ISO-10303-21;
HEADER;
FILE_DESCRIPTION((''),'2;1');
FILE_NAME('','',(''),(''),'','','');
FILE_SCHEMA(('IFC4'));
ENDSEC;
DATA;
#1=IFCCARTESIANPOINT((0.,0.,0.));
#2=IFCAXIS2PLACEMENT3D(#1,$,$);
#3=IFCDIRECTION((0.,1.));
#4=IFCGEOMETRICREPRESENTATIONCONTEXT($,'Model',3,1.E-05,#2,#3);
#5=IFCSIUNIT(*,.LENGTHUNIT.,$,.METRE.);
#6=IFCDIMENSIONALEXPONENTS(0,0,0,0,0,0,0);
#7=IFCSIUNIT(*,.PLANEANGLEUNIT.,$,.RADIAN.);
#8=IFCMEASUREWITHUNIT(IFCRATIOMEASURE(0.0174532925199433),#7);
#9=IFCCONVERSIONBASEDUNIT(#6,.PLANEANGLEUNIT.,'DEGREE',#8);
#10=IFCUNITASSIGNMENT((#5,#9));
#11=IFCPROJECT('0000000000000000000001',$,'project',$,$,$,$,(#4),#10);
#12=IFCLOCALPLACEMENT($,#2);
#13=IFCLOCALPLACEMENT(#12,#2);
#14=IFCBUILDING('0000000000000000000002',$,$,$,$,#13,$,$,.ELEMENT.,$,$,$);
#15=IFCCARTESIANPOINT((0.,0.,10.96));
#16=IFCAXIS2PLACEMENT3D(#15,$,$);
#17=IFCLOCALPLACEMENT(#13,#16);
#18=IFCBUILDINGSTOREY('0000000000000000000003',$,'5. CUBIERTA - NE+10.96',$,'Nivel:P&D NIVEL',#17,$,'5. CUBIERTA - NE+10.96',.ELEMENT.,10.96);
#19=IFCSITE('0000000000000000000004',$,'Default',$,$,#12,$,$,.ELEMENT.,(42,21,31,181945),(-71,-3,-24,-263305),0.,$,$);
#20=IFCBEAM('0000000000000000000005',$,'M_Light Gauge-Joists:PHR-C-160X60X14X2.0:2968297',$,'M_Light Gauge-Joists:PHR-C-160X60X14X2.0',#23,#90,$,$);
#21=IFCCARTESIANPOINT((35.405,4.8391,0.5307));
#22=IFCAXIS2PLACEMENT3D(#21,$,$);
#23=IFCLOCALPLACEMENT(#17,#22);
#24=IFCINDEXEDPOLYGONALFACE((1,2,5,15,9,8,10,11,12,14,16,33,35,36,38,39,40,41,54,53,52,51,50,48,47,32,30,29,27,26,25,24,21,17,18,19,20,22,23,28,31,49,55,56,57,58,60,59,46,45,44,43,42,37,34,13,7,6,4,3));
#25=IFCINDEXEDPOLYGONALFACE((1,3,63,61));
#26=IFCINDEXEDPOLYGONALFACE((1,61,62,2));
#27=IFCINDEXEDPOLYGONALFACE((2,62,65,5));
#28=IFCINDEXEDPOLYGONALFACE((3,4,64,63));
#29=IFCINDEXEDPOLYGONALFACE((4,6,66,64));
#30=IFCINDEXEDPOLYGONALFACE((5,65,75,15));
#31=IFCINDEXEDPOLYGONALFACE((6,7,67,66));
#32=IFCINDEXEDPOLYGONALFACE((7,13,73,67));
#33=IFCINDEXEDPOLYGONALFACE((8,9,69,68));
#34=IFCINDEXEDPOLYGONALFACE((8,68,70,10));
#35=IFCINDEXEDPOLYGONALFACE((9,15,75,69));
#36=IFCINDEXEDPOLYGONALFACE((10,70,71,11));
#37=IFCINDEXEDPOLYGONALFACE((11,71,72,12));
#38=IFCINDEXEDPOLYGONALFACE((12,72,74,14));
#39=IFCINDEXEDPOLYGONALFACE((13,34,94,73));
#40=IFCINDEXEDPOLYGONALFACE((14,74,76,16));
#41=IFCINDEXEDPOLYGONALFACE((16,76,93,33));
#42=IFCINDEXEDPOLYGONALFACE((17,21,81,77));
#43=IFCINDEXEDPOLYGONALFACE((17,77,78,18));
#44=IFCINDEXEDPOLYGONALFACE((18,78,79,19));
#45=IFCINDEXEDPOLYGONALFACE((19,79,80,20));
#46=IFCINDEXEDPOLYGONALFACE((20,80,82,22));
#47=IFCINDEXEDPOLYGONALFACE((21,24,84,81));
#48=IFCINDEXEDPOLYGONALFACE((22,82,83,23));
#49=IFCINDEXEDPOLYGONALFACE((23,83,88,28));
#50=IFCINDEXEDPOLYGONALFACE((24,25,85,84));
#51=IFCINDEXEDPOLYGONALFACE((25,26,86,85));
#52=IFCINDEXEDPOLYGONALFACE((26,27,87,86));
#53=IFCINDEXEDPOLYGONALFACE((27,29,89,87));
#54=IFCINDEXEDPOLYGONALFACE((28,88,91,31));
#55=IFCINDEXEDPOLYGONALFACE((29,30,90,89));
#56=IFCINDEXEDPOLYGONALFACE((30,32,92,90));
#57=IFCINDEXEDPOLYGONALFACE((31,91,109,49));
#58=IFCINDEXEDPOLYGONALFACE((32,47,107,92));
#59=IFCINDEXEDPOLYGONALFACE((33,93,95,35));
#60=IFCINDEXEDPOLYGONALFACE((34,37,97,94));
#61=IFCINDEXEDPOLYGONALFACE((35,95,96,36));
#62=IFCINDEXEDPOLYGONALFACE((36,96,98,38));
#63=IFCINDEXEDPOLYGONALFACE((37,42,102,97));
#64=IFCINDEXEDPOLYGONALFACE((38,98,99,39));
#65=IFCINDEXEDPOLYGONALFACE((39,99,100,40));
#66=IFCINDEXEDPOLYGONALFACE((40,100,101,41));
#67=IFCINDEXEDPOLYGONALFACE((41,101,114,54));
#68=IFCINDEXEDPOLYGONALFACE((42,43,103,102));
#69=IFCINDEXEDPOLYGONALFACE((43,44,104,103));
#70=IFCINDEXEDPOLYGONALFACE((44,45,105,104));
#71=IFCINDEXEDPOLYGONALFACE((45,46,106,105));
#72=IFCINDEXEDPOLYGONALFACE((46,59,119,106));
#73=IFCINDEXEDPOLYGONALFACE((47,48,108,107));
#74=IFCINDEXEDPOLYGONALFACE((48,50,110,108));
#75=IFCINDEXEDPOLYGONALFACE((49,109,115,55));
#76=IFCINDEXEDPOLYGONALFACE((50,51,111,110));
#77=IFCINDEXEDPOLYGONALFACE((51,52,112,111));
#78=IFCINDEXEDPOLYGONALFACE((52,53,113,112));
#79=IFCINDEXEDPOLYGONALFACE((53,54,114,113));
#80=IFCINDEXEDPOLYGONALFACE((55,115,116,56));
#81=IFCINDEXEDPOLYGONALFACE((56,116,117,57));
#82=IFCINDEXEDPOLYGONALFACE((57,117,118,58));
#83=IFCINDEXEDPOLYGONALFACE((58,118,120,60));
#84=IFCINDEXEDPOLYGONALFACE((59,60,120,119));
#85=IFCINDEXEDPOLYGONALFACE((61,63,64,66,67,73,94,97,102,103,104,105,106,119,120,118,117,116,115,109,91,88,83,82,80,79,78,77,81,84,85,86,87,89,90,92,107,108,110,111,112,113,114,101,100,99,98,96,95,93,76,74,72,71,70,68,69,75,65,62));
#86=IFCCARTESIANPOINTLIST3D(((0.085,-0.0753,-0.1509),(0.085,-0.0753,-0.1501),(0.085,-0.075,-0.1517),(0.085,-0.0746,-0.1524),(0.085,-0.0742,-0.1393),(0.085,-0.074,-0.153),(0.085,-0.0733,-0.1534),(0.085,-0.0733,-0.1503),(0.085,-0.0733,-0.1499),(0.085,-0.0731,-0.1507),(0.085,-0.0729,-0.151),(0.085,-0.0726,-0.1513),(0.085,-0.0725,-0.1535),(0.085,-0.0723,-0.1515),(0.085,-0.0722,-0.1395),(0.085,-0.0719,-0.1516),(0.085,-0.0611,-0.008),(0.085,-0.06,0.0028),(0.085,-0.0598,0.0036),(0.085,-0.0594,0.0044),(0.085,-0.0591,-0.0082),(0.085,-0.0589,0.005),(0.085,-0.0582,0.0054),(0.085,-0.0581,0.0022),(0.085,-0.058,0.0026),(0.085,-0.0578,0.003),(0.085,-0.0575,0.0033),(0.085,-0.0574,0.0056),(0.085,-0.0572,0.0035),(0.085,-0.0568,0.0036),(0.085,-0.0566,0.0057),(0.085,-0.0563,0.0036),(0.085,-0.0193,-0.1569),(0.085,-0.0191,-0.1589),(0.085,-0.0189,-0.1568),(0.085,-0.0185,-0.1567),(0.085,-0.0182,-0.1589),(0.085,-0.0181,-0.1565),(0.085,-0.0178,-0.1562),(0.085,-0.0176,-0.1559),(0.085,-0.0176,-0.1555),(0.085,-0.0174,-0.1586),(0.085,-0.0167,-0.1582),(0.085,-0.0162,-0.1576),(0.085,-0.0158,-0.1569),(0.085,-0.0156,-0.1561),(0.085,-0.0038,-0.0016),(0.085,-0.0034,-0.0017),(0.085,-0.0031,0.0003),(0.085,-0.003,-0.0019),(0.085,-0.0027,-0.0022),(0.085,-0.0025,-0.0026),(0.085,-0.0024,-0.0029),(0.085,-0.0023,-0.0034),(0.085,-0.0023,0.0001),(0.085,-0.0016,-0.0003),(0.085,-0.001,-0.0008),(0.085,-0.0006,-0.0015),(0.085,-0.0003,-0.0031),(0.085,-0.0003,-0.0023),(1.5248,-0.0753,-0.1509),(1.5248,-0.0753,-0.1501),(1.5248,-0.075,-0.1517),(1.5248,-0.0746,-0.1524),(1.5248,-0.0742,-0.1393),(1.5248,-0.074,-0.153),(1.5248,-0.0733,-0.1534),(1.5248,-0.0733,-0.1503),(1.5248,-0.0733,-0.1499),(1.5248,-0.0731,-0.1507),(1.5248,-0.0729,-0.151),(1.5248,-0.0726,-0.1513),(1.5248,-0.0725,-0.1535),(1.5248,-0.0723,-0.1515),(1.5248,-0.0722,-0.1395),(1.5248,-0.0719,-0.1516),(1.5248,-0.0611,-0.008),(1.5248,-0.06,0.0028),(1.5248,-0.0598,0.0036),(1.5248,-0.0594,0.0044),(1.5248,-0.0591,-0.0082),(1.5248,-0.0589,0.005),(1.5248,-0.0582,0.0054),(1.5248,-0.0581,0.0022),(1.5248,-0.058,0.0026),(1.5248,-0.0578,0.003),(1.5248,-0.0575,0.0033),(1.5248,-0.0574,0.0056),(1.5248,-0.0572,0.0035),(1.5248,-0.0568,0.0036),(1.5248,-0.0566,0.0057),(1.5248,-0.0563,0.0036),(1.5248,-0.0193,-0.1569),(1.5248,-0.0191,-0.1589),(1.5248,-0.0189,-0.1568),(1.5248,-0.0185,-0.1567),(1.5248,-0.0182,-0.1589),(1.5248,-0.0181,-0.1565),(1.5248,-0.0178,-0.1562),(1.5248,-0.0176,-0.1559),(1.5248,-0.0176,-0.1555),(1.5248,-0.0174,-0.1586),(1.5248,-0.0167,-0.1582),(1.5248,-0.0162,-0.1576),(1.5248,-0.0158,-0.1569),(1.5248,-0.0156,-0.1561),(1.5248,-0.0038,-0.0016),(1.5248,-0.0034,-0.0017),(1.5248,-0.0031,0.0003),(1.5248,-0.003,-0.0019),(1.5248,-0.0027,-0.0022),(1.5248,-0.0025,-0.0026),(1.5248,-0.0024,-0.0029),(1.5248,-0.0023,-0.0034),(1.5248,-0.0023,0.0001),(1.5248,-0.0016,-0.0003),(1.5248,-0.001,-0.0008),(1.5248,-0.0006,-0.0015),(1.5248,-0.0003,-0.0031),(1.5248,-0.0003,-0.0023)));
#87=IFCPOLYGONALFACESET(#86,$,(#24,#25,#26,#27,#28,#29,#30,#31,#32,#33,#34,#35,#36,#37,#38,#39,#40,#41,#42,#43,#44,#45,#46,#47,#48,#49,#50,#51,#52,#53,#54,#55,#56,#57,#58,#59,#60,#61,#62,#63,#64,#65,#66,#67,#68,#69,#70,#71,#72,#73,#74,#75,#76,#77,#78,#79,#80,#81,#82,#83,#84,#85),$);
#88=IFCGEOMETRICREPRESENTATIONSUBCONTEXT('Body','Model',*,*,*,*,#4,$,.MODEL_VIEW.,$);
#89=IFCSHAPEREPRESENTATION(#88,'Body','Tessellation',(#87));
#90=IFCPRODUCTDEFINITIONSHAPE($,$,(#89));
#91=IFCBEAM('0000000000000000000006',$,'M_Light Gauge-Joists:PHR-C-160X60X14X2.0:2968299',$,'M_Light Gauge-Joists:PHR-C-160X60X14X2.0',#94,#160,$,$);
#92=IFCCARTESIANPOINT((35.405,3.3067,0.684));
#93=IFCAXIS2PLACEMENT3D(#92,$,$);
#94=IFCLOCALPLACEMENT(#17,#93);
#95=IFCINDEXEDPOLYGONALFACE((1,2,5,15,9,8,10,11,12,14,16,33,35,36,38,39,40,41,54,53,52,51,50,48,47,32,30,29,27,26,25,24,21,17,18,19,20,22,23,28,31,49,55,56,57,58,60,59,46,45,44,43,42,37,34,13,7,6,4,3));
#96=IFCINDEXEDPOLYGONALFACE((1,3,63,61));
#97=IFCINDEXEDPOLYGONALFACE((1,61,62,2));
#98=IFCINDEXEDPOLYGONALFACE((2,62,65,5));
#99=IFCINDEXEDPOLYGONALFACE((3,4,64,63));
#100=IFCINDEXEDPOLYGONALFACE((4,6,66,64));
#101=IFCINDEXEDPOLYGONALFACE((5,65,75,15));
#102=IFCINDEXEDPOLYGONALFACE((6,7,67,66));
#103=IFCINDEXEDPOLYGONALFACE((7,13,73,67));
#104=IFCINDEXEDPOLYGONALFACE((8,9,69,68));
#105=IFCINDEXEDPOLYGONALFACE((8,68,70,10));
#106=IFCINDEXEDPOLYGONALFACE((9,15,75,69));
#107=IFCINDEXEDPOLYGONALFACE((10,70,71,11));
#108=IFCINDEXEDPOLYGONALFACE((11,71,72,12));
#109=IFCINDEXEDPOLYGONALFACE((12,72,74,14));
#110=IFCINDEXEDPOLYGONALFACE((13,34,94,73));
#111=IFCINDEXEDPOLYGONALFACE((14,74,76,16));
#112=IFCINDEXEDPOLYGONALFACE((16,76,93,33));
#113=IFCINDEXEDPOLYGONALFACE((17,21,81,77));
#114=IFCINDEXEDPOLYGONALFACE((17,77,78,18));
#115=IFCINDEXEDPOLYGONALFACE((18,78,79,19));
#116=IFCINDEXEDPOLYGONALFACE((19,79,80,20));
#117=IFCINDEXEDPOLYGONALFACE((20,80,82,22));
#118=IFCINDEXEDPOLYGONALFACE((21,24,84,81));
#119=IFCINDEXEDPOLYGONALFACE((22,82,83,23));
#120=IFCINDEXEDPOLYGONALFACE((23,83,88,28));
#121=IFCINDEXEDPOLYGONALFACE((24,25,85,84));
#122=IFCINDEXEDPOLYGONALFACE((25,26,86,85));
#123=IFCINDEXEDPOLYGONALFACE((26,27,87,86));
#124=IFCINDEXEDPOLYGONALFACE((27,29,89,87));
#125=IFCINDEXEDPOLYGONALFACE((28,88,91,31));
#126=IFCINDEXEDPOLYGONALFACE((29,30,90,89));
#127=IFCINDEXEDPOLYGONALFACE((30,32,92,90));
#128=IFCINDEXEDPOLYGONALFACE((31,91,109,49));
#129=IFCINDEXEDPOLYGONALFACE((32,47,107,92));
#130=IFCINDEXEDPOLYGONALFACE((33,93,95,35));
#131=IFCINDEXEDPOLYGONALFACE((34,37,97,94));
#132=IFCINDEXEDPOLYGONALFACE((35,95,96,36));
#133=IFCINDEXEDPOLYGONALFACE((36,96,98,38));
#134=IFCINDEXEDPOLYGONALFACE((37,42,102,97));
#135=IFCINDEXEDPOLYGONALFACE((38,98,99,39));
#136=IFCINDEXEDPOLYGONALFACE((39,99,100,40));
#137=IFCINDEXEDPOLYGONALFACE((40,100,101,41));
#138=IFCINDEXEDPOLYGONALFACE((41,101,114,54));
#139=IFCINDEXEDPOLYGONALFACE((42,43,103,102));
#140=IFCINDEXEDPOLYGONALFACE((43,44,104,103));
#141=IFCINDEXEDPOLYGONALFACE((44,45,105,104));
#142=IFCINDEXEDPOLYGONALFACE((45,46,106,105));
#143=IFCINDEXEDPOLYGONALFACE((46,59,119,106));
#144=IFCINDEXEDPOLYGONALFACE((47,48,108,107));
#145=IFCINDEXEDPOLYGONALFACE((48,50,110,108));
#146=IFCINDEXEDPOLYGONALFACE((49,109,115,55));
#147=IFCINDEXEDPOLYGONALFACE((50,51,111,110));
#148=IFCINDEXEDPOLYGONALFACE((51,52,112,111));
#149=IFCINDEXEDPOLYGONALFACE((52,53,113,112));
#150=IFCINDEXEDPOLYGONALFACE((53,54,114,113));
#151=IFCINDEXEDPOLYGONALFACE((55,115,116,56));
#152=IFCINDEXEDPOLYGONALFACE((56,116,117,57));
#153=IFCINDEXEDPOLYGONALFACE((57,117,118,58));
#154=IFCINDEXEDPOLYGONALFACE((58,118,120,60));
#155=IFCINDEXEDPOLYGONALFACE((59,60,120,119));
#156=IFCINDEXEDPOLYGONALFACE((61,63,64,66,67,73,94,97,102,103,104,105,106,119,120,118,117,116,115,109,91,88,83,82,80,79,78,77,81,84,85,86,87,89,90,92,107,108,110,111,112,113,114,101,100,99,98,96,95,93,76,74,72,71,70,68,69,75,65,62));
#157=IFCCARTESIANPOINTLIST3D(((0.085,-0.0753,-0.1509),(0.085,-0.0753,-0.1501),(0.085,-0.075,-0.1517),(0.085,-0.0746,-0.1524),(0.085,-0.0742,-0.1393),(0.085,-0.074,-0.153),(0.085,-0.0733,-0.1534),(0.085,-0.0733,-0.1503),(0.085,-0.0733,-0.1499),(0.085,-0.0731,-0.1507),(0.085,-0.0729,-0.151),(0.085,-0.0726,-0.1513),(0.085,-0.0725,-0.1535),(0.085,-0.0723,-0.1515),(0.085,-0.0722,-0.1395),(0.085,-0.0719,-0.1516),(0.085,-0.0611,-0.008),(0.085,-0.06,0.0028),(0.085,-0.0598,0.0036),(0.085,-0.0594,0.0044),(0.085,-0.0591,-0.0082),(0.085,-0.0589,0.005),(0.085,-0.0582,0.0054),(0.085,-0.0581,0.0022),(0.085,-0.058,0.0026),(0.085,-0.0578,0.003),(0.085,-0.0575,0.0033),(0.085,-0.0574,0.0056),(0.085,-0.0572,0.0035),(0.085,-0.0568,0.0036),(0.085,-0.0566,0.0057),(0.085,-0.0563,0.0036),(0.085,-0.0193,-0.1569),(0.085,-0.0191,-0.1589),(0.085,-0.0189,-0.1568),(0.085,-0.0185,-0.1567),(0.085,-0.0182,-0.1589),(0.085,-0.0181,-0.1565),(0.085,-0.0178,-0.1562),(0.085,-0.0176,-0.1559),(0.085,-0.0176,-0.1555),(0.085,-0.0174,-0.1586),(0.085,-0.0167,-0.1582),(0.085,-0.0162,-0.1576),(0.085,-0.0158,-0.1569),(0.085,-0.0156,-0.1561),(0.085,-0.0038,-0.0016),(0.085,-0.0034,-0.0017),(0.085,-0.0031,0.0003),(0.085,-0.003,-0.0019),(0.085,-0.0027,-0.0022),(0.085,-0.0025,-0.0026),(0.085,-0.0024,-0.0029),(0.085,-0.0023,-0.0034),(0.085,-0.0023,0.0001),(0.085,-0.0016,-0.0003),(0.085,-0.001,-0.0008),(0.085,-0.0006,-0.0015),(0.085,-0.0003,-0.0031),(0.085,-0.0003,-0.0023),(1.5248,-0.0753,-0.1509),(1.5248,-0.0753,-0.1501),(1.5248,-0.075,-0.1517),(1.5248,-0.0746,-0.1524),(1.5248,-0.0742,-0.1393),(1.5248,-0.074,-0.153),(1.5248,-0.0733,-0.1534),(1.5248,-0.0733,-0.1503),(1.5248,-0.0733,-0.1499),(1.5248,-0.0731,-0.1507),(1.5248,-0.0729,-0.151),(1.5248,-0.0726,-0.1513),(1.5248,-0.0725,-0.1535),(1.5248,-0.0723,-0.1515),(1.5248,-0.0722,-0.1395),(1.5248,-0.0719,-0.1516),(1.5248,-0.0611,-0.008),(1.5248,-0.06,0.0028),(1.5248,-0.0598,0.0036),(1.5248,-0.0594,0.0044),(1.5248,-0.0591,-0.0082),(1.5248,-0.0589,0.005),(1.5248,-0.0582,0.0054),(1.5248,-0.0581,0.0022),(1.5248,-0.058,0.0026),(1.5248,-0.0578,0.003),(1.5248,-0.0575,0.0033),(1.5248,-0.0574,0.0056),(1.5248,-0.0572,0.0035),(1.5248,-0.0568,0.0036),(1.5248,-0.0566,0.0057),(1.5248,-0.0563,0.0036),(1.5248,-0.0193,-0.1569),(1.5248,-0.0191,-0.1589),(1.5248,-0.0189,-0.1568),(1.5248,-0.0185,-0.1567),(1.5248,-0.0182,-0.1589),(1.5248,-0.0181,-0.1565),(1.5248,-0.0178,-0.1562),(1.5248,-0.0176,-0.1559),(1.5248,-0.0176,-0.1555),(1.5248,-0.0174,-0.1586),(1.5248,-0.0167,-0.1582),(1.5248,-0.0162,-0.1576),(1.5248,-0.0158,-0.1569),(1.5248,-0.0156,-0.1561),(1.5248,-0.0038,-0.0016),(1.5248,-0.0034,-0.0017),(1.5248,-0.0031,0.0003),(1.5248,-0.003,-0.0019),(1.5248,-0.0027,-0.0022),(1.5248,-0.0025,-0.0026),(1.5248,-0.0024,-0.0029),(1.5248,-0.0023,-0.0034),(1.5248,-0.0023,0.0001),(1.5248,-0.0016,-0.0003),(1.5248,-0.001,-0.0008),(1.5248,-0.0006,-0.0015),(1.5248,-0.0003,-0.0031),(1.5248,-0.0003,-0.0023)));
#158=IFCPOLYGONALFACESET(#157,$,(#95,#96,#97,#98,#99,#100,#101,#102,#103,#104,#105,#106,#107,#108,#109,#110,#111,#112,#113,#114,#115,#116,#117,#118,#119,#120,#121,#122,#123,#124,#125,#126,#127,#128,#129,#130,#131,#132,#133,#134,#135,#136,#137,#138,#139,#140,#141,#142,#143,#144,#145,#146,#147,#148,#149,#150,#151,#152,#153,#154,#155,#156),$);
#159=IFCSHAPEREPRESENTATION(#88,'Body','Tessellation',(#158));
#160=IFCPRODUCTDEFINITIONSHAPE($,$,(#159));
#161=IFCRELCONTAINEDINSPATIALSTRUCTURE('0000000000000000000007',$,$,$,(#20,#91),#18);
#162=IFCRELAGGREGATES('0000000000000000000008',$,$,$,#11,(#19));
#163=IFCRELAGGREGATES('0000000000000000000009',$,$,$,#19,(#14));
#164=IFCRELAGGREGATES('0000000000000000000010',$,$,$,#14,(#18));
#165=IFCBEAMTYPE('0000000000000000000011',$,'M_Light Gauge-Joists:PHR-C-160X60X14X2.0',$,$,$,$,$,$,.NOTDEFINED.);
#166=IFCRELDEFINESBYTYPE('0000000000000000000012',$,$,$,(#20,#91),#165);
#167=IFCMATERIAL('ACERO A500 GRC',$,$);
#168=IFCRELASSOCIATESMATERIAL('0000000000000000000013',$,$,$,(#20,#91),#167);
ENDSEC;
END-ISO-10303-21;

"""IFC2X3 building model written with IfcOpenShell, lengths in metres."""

from ifc_helpers import new_model, entity, si_unit, converted_unit, direction, frame, frame_2d, origin, place, context, subcontext, project, spatial, polyline, circle_curve, parameter, trimmed, segment, composite_curve, outline, extrude, material, type_object, element, save


model = new_model("IFC2X3")

# Units and contexts
model_context = context("Model", 3, precision=1e-05, world=origin(), true_north=direction((0.0, 1.0)))
body_context = subcontext(model_context, "Body", "Model", "MODEL_VIEW")
ifc_project = project(units=[si_unit("LENGTHUNIT", "METRE"), converted_unit("PLANEANGLEUNIT", "DEGREE", entity("IfcRatioMeasure", 0.0174532925199433), si_unit("PLANEANGLEUNIT", "RADIAN"), dimensions=[0, 0, 0, 0, 0, 0, 0])], contexts=[model_context])

# Site, building, storey
site_placement = place(None, origin())
site = spatial("IfcSite", under=ifc_project, at=site_placement, Name="Default", CompositionType="ELEMENT", RefLatitude=(42, 21, 31, 181945), RefLongitude=(-71, -3, -24, -263305), RefElevation=0.0)
building_placement = place(site_placement, origin())
building = spatial("IfcBuilding", under=site, at=building_placement, CompositionType="ELEMENT")
storey_placement = place(building_placement, frame((0.0, 0.0, 10.96)))
storey = spatial("IfcBuildingStorey", under=building, at=storey_placement, Name="5. CUBIERTA - NE+10.96", ObjectType="Nivel:P&D NIVEL", LongName="5. CUBIERTA - NE+10.96", CompositionType="ELEMENT", Elevation=10.96)

# Beams
ifc_material_1 = material(Name="ACERO A500 GRC")
beam_type_1 = type_object("IfcBeamType", Name="M_Light Gauge-Joists:PHR-C-160X60X14X2.0", PredefinedType="NOTDEFINED")
beam_1_placement = place(storey_placement, frame((35.405, 4.8391, 0.5307)))
element("IfcBeam", 1, at=beam_1_placement, inside=storey, type_object=beam_type_1, material=ifc_material_1, Name="M_Light Gauge-Joists:PHR-C-160X60X14X2.0:2968297", ObjectType="M_Light Gauge-Joists:PHR-C-160X60X14X2.0", context=body_context, shape_type="SweptSolid", body=[
    extrude(outline(composite_curve([segment(polyline([(-0.0768, -0.0358), (0.0768, -0.0358)]), True, "CONTINUOUS"), segment(trimmed(circle_curve(frame_2d((0.0768, -0.0326), x_axis=(0.0, -1.0)), 0.0032), [parameter(0.0)], [parameter(90.0)], True, "PARAMETER"), True, "CONTINUOUS"), segment(polyline([(0.08, -0.0326), (0.08, 0.021)]), True, "CONTINUOUS"), segment(trimmed(circle_curve(frame_2d((0.0768, 0.021), x_axis=(1.0, 0.0)), 0.0032), [parameter(0.0)], [parameter(90.0)], True, "PARAMETER"), True, "CONTINUOUS"), segment(polyline([(0.0768, 0.0242), (0.066, 0.0242)]), True, "CONTINUOUS"), segment(polyline([(0.066, 0.0242), (0.066, 0.0222)]), True, "CONTINUOUS"), segment(polyline([(0.066, 0.0222), (0.0764, 0.0222)]), True, "CONTINUOUS"), segment(trimmed(circle_curve(frame_2d((0.0764, 0.0206), x_axis=(0.0, 1.0)), 0.0016), [parameter(270.0)], [parameter(0.0)], True, "PARAMETER"), False, "CONTINUOUS"), segment(polyline([(0.078, 0.0206), (0.078, -0.0322)]), True, "CONTINUOUS"), segment(trimmed(circle_curve(frame_2d((0.0764, -0.0322), x_axis=(1.0, 0.0)), 0.0016), [parameter(270.0)], [parameter(0.0)], True, "PARAMETER"), False, "CONTINUOUS"), segment(polyline([(0.0764, -0.0338), (-0.0764, -0.0338)]), True, "CONTINUOUS"), segment(trimmed(circle_curve(frame_2d((-0.0764, -0.0322), x_axis=(0.0, -1.0)), 0.0016), [parameter(270.0)], [parameter(0.0)], True, "PARAMETER"), False, "CONTINUOUS"), segment(polyline([(-0.078, -0.0322), (-0.078, 0.0206)]), True, "CONTINUOUS"), segment(trimmed(circle_curve(frame_2d((-0.0764, 0.0206), x_axis=(-1.0, 0.0)), 0.0016), [parameter(270.0)], [parameter(0.0)], True, "PARAMETER"), False, "CONTINUOUS"), segment(polyline([(-0.0764, 0.0222), (-0.066, 0.0222)]), True, "CONTINUOUS"), segment(polyline([(-0.066, 0.0222), (-0.066, 0.0242)]), True, "CONTINUOUS"), segment(polyline([(-0.066, 0.0242), (-0.0768, 0.0242)]), True, "CONTINUOUS"), segment(trimmed(circle_curve(frame_2d((-0.0768, 0.021), x_axis=(0.0, 1.0)), 0.0032), [parameter(0.0)], [parameter(90.0)], True, "PARAMETER"), True, "CONTINUOUS"), segment(polyline([(-0.08, 0.021), (-0.08, -0.0326)]), True, "CONTINUOUS"), segment(trimmed(circle_curve(frame_2d((-0.0768, -0.0326), x_axis=(-1.0, 0.0)), 0.0032), [parameter(0.0)], [parameter(90.0)], True, "PARAMETER"), True, "CONTINUOUS")], self_intersect=False)), frame((0.085, -0.0436, -0.076), z_axis=(1.0, 0.0, 0.0), x_axis=(0.0, 0.099504, 0.995037)), (0.0, 0.0, 1.0), 1.4398),
])
beam_2_placement = place(storey_placement, frame((35.405, 3.3067, 0.684)))
element("IfcBeam", 2, at=beam_2_placement, inside=storey, type_object=beam_type_1, material=ifc_material_1, Name="M_Light Gauge-Joists:PHR-C-160X60X14X2.0:2968299", ObjectType="M_Light Gauge-Joists:PHR-C-160X60X14X2.0", context=body_context, shape_type="SweptSolid", body=[
    extrude(outline(composite_curve([segment(polyline([(-0.0768, -0.0358), (0.0768, -0.0358)]), True, "CONTINUOUS"), segment(trimmed(circle_curve(frame_2d((0.0768, -0.0326), x_axis=(0.0, -1.0)), 0.0032), [parameter(0.0)], [parameter(90.0)], True, "PARAMETER"), True, "CONTINUOUS"), segment(polyline([(0.08, -0.0326), (0.08, 0.021)]), True, "CONTINUOUS"), segment(trimmed(circle_curve(frame_2d((0.0768, 0.021), x_axis=(1.0, 0.0)), 0.0032), [parameter(0.0)], [parameter(90.0)], True, "PARAMETER"), True, "CONTINUOUS"), segment(polyline([(0.0768, 0.0242), (0.066, 0.0242)]), True, "CONTINUOUS"), segment(polyline([(0.066, 0.0242), (0.066, 0.0222)]), True, "CONTINUOUS"), segment(polyline([(0.066, 0.0222), (0.0764, 0.0222)]), True, "CONTINUOUS"), segment(trimmed(circle_curve(frame_2d((0.0764, 0.0206), x_axis=(0.0, 1.0)), 0.0016), [parameter(270.0)], [parameter(0.0)], True, "PARAMETER"), False, "CONTINUOUS"), segment(polyline([(0.078, 0.0206), (0.078, -0.0322)]), True, "CONTINUOUS"), segment(trimmed(circle_curve(frame_2d((0.0764, -0.0322), x_axis=(1.0, 0.0)), 0.0016), [parameter(270.0)], [parameter(0.0)], True, "PARAMETER"), False, "CONTINUOUS"), segment(polyline([(0.0764, -0.0338), (-0.0764, -0.0338)]), True, "CONTINUOUS"), segment(trimmed(circle_curve(frame_2d((-0.0764, -0.0322), x_axis=(0.0, -1.0)), 0.0016), [parameter(270.0)], [parameter(0.0)], True, "PARAMETER"), False, "CONTINUOUS"), segment(polyline([(-0.078, -0.0322), (-0.078, 0.0206)]), True, "CONTINUOUS"), segment(trimmed(circle_curve(frame_2d((-0.0764, 0.0206), x_axis=(-1.0, 0.0)), 0.0016), [parameter(270.0)], [parameter(0.0)], True, "PARAMETER"), False, "CONTINUOUS"), segment(polyline([(-0.0764, 0.0222), (-0.066, 0.0222)]), True, "CONTINUOUS"), segment(polyline([(-0.066, 0.0222), (-0.066, 0.0242)]), True, "CONTINUOUS"), segment(polyline([(-0.066, 0.0242), (-0.0768, 0.0242)]), True, "CONTINUOUS"), segment(trimmed(circle_curve(frame_2d((-0.0768, 0.021), x_axis=(0.0, 1.0)), 0.0032), [parameter(0.0)], [parameter(90.0)], True, "PARAMETER"), True, "CONTINUOUS"), segment(polyline([(-0.08, 0.021), (-0.08, -0.0326)]), True, "CONTINUOUS"), segment(trimmed(circle_curve(frame_2d((-0.0768, -0.0326), x_axis=(-1.0, 0.0)), 0.0032), [parameter(0.0)], [parameter(90.0)], True, "PARAMETER"), True, "CONTINUOUS")], self_intersect=False)), frame((0.085, -0.0436, -0.076), z_axis=(1.0, 0.0, 0.0), x_axis=(0.0, 0.099504, 0.995037)), (0.0, 0.0, 1.0), 1.4398),
])

save(model, "model.ifc")
